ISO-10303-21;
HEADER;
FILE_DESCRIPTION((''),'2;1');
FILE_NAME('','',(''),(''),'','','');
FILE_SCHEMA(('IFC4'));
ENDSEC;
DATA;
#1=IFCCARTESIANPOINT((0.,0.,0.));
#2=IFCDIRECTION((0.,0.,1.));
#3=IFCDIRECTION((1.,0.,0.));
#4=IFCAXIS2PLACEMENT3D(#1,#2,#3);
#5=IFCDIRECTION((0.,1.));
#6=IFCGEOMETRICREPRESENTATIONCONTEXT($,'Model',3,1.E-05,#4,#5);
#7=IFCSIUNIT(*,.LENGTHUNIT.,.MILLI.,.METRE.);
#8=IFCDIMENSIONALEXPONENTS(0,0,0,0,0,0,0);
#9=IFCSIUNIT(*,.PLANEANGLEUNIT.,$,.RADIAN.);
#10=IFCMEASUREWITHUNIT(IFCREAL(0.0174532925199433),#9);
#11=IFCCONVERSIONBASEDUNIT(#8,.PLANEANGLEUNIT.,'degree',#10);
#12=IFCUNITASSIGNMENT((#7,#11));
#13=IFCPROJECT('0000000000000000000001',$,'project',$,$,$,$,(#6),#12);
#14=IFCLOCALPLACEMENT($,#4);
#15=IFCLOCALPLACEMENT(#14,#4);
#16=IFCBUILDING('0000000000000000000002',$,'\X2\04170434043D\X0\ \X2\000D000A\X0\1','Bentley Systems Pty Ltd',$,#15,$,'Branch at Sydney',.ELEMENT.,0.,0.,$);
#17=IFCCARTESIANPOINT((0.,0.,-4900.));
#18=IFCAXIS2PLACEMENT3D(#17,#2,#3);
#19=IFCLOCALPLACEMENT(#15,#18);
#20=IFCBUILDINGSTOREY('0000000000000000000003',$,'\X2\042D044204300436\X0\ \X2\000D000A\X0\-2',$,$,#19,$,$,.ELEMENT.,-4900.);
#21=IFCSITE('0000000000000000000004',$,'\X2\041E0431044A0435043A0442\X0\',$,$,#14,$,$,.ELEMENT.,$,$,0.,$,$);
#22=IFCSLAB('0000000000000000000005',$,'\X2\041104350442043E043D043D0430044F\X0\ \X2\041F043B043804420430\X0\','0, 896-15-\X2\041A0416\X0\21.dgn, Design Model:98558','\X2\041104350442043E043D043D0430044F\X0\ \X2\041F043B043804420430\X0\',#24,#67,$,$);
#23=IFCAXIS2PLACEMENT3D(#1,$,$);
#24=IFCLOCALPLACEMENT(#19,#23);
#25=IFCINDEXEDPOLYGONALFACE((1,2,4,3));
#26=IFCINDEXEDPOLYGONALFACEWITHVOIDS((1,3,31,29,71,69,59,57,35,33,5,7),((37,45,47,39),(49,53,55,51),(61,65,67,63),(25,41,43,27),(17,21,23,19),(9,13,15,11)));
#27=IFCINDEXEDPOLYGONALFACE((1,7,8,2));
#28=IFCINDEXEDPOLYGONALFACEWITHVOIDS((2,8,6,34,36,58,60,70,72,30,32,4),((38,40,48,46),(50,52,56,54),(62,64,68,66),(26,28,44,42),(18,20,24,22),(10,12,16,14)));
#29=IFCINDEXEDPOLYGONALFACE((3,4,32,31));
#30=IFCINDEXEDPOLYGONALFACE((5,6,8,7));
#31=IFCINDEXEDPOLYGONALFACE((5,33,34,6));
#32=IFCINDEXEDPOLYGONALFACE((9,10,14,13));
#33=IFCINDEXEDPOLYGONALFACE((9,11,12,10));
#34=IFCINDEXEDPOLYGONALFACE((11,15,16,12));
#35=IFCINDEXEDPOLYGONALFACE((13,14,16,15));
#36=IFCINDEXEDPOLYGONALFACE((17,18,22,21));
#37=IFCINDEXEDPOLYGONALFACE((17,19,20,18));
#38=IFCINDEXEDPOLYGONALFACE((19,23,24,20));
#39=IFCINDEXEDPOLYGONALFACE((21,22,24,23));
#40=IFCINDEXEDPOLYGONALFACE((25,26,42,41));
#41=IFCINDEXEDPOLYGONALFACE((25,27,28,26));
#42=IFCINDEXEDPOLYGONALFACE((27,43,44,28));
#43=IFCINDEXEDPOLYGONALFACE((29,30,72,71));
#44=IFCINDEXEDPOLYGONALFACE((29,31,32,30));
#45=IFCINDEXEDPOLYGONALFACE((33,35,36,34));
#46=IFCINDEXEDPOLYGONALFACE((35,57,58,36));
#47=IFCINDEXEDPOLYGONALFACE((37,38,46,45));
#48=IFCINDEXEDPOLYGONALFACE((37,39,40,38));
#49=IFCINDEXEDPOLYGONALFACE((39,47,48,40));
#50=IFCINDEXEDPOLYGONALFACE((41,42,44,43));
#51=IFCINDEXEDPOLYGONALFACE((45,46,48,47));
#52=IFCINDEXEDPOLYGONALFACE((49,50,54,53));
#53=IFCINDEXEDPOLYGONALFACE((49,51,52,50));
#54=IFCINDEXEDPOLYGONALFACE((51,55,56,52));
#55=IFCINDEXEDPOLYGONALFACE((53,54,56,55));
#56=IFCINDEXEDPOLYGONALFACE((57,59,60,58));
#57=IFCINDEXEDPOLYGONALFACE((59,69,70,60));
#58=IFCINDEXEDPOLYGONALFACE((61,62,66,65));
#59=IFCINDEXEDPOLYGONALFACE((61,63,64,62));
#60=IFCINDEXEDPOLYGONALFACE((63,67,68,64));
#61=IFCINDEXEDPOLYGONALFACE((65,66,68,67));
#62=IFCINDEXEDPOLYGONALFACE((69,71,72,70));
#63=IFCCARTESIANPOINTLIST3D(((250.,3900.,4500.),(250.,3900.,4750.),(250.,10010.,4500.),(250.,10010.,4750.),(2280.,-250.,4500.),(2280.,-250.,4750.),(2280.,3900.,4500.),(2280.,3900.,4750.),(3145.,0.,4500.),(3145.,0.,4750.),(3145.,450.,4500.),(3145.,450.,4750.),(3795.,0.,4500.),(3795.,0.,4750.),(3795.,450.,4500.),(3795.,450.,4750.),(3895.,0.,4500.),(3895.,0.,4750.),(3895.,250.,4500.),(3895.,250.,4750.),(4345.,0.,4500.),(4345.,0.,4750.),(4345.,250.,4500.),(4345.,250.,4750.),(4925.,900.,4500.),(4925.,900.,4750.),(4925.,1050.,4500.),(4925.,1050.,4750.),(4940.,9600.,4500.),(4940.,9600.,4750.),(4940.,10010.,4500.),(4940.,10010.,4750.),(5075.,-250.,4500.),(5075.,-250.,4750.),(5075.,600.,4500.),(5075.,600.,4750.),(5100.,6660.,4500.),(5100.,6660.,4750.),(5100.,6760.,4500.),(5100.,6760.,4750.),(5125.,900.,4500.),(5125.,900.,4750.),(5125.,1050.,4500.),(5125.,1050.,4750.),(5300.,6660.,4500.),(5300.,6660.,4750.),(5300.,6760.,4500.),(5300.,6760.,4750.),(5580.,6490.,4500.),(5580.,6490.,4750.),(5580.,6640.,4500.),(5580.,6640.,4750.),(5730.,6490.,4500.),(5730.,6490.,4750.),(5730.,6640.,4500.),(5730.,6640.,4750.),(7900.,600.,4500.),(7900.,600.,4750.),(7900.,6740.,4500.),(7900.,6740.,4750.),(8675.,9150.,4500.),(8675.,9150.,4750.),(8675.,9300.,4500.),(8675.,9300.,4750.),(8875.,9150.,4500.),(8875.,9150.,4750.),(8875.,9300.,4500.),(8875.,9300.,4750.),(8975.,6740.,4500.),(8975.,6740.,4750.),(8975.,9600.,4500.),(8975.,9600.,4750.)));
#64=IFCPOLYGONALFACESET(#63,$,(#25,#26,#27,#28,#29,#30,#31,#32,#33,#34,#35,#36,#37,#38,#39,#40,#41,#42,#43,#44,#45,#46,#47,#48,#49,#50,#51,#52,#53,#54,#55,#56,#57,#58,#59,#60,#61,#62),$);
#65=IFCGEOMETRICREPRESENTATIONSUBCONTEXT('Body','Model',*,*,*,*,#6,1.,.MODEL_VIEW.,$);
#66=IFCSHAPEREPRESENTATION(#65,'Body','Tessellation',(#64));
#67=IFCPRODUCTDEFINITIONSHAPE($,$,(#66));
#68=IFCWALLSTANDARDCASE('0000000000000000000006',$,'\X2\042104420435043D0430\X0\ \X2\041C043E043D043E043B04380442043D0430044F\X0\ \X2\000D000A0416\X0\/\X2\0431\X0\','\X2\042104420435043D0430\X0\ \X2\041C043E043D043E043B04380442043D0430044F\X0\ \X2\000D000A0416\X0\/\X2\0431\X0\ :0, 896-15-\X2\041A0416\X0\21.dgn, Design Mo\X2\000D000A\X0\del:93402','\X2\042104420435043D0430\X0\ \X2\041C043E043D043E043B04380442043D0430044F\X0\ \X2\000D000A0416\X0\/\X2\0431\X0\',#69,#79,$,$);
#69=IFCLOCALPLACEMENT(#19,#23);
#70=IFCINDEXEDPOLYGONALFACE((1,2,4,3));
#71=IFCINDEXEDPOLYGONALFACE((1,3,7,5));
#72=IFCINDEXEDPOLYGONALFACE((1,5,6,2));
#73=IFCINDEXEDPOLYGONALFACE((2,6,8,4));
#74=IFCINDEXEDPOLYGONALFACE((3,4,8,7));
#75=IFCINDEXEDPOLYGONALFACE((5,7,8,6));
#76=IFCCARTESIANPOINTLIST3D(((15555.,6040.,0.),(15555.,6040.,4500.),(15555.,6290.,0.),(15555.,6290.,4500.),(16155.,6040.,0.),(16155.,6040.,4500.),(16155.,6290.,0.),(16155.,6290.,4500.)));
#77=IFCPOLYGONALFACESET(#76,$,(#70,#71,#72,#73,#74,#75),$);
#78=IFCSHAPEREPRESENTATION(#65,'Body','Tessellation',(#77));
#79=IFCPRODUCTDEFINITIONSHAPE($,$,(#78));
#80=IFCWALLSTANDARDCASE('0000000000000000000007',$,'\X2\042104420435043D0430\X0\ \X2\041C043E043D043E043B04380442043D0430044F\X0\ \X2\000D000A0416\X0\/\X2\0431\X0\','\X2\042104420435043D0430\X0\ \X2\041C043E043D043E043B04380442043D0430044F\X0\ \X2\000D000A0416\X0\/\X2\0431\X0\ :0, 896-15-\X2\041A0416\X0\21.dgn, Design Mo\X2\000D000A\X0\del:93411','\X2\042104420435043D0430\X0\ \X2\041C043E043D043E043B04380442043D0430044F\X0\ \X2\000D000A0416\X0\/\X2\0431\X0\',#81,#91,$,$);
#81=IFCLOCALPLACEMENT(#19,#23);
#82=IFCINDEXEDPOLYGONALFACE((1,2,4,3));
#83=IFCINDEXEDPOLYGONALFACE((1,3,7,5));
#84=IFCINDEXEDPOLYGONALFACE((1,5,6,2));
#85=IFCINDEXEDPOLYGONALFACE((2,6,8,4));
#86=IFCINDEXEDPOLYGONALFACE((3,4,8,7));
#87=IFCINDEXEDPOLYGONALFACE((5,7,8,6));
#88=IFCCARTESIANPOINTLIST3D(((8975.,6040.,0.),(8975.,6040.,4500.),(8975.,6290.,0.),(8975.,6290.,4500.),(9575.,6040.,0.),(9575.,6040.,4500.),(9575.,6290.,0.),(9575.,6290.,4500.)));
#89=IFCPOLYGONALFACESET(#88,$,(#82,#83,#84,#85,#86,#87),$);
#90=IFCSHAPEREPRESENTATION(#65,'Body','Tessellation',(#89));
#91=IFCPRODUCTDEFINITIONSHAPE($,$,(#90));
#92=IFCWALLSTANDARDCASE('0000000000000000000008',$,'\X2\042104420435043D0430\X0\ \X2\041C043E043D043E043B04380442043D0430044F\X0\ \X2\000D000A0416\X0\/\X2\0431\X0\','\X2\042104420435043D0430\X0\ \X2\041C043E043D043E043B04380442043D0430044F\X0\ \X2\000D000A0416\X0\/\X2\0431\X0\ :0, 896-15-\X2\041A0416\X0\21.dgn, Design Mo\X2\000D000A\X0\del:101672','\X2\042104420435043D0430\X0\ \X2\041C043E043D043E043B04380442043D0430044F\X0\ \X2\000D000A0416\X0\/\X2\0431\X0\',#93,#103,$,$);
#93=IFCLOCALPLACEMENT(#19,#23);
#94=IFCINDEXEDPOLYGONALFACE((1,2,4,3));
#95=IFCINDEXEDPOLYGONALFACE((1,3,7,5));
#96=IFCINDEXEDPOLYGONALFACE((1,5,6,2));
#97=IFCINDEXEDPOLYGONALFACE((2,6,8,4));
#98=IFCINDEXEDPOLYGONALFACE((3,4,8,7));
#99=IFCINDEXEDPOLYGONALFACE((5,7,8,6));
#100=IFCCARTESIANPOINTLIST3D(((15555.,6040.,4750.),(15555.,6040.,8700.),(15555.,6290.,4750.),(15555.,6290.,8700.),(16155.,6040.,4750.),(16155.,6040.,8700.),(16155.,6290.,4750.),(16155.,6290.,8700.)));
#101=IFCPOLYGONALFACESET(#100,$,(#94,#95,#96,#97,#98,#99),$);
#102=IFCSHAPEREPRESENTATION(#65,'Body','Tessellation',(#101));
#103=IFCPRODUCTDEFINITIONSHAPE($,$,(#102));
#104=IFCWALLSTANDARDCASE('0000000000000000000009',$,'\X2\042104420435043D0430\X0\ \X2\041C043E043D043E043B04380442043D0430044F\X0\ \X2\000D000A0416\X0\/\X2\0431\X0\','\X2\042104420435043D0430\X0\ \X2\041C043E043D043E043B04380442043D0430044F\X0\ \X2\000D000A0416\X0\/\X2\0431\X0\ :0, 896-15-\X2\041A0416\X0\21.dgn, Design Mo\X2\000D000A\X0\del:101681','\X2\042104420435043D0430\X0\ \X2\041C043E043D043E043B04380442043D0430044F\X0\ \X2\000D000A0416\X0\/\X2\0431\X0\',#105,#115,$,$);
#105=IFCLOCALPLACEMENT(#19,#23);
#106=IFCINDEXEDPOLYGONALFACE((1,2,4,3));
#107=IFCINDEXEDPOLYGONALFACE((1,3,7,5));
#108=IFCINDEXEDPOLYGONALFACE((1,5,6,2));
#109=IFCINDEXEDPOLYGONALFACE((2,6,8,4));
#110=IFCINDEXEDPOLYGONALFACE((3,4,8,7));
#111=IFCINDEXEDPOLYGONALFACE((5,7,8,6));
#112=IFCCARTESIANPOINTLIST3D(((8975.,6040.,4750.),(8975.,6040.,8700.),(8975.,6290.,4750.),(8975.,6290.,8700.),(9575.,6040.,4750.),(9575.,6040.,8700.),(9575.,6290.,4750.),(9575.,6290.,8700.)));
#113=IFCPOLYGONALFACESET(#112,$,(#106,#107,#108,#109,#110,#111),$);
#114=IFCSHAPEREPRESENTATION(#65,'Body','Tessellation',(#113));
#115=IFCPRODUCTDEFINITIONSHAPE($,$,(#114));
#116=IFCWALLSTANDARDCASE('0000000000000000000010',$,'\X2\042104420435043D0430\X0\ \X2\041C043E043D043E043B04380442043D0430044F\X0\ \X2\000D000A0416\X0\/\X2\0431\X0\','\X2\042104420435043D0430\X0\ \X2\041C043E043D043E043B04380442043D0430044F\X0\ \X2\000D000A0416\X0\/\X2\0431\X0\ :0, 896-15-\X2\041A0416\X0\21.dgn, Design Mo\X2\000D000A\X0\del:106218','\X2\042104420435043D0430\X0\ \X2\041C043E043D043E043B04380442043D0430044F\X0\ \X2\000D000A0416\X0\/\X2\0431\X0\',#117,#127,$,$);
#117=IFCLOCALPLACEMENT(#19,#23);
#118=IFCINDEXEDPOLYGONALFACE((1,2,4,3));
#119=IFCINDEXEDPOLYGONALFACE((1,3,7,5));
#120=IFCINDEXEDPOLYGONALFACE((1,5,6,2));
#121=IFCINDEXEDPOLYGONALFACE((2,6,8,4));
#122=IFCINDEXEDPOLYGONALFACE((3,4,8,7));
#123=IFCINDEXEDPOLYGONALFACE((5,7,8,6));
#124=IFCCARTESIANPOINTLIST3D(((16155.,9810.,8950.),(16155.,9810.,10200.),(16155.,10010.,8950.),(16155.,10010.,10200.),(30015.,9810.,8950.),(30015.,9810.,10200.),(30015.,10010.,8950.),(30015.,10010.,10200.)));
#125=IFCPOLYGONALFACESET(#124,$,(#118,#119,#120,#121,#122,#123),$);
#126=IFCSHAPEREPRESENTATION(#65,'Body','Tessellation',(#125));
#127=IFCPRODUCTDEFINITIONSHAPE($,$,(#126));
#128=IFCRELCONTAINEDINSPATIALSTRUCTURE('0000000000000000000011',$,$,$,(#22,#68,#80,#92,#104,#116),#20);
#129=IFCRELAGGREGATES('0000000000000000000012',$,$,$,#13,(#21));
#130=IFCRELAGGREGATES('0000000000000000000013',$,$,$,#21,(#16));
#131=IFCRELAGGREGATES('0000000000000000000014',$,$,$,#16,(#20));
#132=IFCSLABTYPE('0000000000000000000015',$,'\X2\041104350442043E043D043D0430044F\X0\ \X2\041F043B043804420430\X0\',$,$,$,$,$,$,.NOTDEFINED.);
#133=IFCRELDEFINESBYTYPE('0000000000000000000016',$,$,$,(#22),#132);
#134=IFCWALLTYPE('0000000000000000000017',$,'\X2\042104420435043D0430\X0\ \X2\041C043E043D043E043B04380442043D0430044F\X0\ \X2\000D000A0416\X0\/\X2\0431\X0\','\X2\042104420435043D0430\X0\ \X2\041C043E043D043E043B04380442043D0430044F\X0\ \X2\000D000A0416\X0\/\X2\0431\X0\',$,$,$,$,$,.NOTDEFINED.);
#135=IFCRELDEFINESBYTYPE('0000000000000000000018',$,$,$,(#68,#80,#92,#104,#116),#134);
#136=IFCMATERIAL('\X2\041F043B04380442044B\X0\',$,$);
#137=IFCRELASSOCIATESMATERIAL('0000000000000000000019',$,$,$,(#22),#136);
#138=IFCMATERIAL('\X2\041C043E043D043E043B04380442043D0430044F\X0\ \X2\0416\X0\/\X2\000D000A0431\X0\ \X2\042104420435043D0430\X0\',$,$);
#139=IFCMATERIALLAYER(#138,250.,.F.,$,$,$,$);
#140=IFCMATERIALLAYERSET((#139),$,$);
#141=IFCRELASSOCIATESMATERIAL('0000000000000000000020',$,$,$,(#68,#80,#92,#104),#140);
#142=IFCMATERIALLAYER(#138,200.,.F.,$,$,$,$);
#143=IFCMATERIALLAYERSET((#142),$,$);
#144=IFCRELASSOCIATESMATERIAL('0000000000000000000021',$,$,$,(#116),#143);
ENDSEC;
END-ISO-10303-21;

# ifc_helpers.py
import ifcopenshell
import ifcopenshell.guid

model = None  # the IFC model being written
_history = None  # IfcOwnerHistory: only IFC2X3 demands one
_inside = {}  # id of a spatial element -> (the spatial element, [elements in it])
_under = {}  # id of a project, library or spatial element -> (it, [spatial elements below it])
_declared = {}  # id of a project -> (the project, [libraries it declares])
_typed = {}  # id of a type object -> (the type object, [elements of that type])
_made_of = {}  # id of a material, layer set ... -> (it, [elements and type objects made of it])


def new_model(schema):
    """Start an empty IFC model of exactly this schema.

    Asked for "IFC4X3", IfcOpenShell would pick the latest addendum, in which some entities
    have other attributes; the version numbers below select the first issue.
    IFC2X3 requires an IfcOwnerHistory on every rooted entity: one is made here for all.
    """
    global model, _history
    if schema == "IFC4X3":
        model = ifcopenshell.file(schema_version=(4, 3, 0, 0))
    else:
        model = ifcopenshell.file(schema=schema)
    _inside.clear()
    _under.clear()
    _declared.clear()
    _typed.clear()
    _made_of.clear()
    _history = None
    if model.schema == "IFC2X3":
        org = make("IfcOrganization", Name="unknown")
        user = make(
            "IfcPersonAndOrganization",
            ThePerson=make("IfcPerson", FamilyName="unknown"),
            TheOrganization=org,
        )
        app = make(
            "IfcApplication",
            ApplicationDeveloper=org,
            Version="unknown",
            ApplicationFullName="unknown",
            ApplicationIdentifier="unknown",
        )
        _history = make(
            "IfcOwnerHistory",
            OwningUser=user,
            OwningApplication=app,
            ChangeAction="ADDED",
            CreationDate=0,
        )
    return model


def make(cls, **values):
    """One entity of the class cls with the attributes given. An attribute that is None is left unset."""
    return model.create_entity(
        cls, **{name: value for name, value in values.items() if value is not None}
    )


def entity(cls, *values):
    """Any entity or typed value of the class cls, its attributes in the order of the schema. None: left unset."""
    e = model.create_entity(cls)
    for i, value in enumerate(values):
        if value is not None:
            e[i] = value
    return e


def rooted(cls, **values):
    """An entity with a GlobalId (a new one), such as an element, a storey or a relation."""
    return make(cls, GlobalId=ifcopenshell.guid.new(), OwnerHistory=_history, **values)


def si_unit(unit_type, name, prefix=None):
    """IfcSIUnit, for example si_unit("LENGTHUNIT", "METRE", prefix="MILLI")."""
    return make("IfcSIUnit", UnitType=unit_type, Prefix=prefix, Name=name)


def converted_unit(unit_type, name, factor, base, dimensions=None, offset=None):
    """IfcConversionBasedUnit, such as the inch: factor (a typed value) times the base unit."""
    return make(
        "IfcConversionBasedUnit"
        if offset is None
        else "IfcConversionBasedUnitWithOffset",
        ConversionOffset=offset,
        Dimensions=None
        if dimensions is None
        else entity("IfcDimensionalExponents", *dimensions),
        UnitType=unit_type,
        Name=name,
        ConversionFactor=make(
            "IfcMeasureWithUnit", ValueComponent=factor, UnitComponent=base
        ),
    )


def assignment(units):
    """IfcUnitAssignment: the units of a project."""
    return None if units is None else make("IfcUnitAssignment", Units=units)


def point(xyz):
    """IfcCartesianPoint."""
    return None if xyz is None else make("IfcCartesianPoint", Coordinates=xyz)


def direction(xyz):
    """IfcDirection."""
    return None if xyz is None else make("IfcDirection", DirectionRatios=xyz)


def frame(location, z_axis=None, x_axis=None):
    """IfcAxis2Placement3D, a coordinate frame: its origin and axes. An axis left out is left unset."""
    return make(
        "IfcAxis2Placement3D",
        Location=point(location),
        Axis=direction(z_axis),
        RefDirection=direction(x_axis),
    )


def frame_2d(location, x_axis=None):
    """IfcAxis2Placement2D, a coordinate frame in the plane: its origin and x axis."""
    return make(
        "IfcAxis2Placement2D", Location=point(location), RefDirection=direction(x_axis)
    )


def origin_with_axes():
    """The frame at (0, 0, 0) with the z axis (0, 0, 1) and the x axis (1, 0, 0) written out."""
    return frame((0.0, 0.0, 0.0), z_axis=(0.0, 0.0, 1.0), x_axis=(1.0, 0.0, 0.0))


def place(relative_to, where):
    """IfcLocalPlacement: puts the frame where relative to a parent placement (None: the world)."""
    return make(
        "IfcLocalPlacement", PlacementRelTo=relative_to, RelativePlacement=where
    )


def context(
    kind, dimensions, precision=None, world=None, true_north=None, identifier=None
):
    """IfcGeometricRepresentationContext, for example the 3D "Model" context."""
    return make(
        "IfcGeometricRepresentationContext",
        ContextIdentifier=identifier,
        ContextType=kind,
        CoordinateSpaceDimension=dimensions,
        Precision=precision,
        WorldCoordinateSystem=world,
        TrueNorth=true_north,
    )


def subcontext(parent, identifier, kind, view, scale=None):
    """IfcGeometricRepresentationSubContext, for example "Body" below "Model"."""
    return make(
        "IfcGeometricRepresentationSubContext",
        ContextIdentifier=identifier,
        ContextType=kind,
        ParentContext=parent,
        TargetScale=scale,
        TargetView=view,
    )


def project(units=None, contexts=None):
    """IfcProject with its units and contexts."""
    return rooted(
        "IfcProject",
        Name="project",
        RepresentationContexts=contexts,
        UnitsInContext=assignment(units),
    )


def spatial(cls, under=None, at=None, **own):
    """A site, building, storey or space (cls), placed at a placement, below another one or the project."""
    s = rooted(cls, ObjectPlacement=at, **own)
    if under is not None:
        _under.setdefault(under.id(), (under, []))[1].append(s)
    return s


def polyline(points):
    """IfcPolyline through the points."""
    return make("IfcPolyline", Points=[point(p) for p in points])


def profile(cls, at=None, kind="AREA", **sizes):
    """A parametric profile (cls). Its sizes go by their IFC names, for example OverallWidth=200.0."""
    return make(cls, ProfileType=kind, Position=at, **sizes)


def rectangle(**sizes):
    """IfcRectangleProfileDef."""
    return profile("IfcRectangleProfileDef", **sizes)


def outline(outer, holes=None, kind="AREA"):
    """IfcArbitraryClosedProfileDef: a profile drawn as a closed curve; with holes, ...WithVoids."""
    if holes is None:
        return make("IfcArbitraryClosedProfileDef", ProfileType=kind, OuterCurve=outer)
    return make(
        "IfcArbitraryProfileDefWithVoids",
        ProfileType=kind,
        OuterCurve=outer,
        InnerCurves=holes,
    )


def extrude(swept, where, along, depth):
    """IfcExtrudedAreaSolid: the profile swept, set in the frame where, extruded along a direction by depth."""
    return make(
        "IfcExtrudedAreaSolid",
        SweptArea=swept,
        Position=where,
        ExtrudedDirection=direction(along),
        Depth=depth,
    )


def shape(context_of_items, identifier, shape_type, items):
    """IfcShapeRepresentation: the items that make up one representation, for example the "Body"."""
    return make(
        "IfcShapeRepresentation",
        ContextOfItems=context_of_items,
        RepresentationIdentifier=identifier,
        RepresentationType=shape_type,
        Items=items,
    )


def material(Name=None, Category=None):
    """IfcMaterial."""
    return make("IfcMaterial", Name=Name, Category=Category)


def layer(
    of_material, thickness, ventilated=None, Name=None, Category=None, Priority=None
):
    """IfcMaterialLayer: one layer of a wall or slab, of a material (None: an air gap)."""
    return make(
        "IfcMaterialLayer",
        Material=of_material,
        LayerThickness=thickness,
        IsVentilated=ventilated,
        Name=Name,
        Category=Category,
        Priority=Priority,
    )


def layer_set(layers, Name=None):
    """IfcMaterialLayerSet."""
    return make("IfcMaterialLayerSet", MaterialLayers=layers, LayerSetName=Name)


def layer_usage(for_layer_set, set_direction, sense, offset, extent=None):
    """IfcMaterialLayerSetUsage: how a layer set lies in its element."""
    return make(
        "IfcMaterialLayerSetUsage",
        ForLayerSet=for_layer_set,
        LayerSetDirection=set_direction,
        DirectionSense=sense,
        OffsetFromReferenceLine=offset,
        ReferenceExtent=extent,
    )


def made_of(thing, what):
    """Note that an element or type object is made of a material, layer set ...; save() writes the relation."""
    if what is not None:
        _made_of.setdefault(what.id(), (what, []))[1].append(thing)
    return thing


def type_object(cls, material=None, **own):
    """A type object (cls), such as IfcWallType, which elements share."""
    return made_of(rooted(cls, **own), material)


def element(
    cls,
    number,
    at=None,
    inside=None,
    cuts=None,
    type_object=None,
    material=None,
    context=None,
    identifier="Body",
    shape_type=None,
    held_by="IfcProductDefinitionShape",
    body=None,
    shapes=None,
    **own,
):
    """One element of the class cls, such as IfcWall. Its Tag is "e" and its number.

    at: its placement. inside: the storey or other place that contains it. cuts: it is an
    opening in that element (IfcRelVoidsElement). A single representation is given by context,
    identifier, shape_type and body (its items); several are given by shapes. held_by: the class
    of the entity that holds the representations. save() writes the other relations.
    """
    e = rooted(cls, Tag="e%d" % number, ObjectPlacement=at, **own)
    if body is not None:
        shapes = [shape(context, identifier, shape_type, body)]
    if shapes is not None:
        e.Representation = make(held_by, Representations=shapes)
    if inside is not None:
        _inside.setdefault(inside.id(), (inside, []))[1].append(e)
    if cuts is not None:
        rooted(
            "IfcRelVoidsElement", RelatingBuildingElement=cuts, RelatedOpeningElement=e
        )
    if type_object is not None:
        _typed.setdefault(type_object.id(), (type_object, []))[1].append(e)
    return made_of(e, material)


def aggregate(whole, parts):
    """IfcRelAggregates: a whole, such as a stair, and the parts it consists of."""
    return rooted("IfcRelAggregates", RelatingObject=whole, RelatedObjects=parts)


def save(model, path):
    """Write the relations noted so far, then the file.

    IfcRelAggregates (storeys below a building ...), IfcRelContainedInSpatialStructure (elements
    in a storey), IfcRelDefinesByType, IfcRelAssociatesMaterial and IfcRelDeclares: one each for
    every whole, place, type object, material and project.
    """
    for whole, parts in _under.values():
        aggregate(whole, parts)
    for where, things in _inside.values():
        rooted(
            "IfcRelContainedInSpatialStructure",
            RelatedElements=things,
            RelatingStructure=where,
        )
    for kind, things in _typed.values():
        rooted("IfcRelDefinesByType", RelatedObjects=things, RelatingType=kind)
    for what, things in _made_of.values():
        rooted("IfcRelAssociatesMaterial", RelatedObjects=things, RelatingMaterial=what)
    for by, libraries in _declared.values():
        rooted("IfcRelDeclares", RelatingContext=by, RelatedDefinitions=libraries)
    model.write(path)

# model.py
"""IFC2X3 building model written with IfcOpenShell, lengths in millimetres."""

from ifc_helpers import new_model, entity, si_unit, converted_unit, direction, frame, frame_2d, origin_with_axes, place, context, subcontext, project, spatial, polyline, rectangle, outline, extrude, material, layer, layer_set, layer_usage, type_object, element, save


model = new_model("IFC2X3")

# Units and contexts
model_context = context("Model", 3, precision=1e-05, world=origin_with_axes(), true_north=direction((0.0, 1.0)))
body_context = subcontext(model_context, "Body", "Model", "MODEL_VIEW", scale=1.0)
ifc_project = project(units=[si_unit("LENGTHUNIT", "METRE", prefix="MILLI"), converted_unit("PLANEANGLEUNIT", "degree", entity("IfcReal", 0.0174532925199433), si_unit("PLANEANGLEUNIT", "RADIAN"), dimensions=[0, 0, 0, 0, 0, 0, 0])], contexts=[model_context])

# Site, building, storey
site_placement = place(None, origin_with_axes())
site = spatial("IfcSite", under=ifc_project, at=site_placement, Name="Объект", CompositionType="ELEMENT", RefElevation=0.0)
building_placement = place(site_placement, origin_with_axes())
building = spatial("IfcBuilding", under=site, at=building_placement, Name="Здн \r\n1", Description="Bentley Systems Pty Ltd", LongName="Branch at Sydney", CompositionType="ELEMENT", ElevationOfRefHeight=0.0, ElevationOfTerrain=0.0)
storey_placement = place(building_placement, frame((0.0, 0.0, -4900.0), z_axis=(0.0, 0.0, 1.0), x_axis=(1.0, 0.0, 0.0)))
storey = spatial("IfcBuildingStorey", under=building, at=storey_placement, Name="Этаж \r\n-2", CompositionType="ELEMENT", Elevation=-4900.0)

# Shared definitions
ifc_material_1 = material(Name="Плиты")
slab_type = type_object("IfcSlabType", Name="Бетонная Плита", PredefinedType="NOTDEFINED")

# Slab, openings
slab_1_placement = place(storey_placement, frame((8975.0, 9600.0, 4750.0), z_axis=(0.0, 0.0, -1.0), x_axis=(0.0, -1.0, 0.0)))
slab_1 = element("IfcSlab", 1, at=slab_1_placement, inside=storey, type_object=slab_type, material=ifc_material_1, Name="Бетонная Плита", Description="0, 896-15-КЖ21.dgn, Design Model:98558", ObjectType="Бетонная Плита", context=body_context, shape_type="SweptSolid", body=[
    extrude(outline(polyline([(0.0, 0.0), (2860.0, 0.0), (2860.0, 1075.0), (9000.0, 1075.0), (9000.0, 3900.0), (9850.0, 3900.0), (9850.0, 6695.0), (5700.0, 6695.0), (5700.0, 8725.0), (-410.0, 8725.0), (-410.0, 4035.0), (0.0, 4035.0), (0.0, 0.0)])), origin_with_axes(), (0.0, 0.0, 1.0), 250.0),
])
opening_1_placement = place(slab_1_placement, frame((300.0, 100.0, 0.0), z_axis=(0.0, 0.0, 1.0), x_axis=(1.0, 0.0, 0.0)))
element("IfcOpeningElement", 2, at=opening_1_placement, cuts=slab_1, ObjectType="Opening", context=body_context, shape_type="SweptSolid", body=[
    extrude(rectangle(XDim=200.0, YDim=150.0, at=frame_2d((-75.0, 100.0), x_axis=(0.0, 1.0))), frame((0.0, 0.0, 375.0), z_axis=(0.0, 0.0, -1.0), x_axis=(-1.0, 0.0, 0.0)), (0.0, 0.0, 1.0), 750.0),
])
opening_2_placement = place(slab_1_placement, frame((2960.0, 3245.0, 0.0), z_axis=(0.0, 0.0, 1.0), x_axis=(1.0, 0.0, 0.0)))
element("IfcOpeningElement", 3, at=opening_2_placement, cuts=slab_1, ObjectType="Opening", context=body_context, shape_type="SweptSolid", body=[
    extrude(rectangle(XDim=150.0, YDim=150.0, at=frame_2d((-75.0, 75.0), x_axis=(0.0, 1.0))), frame((0.0, 0.0, 375.0), z_axis=(0.0, 0.0, -1.0), x_axis=(-1.0, 0.0, 0.0)), (0.0, 0.0, 1.0), 750.0),
])
opening_3_placement = place(slab_1_placement, frame((2840.0, 3675.0, 0.0), z_axis=(0.0, 0.0, 1.0), x_axis=(1.0, 0.0, 0.0)))
element("IfcOpeningElement", 4, at=opening_3_placement, cuts=slab_1, ObjectType="Opening", context=body_context, shape_type="SweptSolid", body=[
    extrude(rectangle(XDim=200.0, YDim=100.0, at=frame_2d((-50.0, 100.0), x_axis=(0.0, 1.0))), frame((0.0, 0.0, 375.0), z_axis=(0.0, 0.0, -1.0), x_axis=(-1.0, 0.0, 0.0)), (0.0, 0.0, 1.0), 750.0),
])
opening_4_placement = place(slab_1_placement, frame((9150.0, 5180.0, 0.0), z_axis=(0.0, 0.0, 1.0), x_axis=(1.0, 0.0, 0.0)))
element("IfcOpeningElement", 5, at=opening_4_placement, cuts=slab_1, ObjectType="Opening", context=body_context, shape_type="SweptSolid", body=[
    extrude(rectangle(XDim=650.0, YDim=450.0, at=frame_2d((-225.0, 325.0), x_axis=(0.0, 1.0))), frame((0.0, 0.0, 375.0), z_axis=(0.0, 0.0, -1.0), x_axis=(-1.0, 0.0, 0.0)), (0.0, 0.0, 1.0), 750.0),
])
opening_5_placement = place(slab_1_placement, frame((9350.0, 4630.0, 0.0), z_axis=(0.0, 0.0, 1.0), x_axis=(1.0, 0.0, 0.0)))
element("IfcOpeningElement", 6, at=opening_5_placement, cuts=slab_1, ObjectType="Opening", context=body_context, shape_type="SweptSolid", body=[
    extrude(rectangle(XDim=450.0, YDim=250.0, at=frame_2d((-125.0, 225.0), x_axis=(0.0, 1.0))), frame((0.0, 0.0, 375.0), z_axis=(0.0, 0.0, -1.0), x_axis=(-1.0, 0.0, 0.0)), (0.0, 0.0, 1.0), 750.0),
])
opening_6_placement = place(slab_1_placement, frame((8550.0, 3850.0, 0.0), z_axis=(0.0, 0.0, 1.0), x_axis=(1.0, 0.0, 0.0)))
element("IfcOpeningElement", 7, at=opening_6_placement, cuts=slab_1, ObjectType="Opening", context=body_context, shape_type="SweptSolid", body=[
    extrude(rectangle(XDim=200.0, YDim=150.0, at=frame_2d((-75.0, 100.0), x_axis=(0.0, 1.0))), frame((0.0, 0.0, 375.0), z_axis=(0.0, 0.0, -1.0), x_axis=(-1.0, 0.0, 0.0)), (0.0, 0.0, 1.0), 750.0),
])

# Walls
ifc_material_2 = material(Name="Монолитная Ж/\r\nб Стена")
ifc_layer_1 = layer(ifc_material_2, 250.0, ventilated=False)
ifc_layer_set_1 = layer_set([ifc_layer_1])
ifc_layer_usage_1 = layer_usage(ifc_layer_set_1, "AXIS2", "POSITIVE", 0.0)
wall_type = type_object("IfcWallType", Name="Стена Монолитная \r\nЖ/б", Description="Стена Монолитная \r\nЖ/б", PredefinedType="NOTDEFINED")
for number, where, z_axis, x_axis, name, description in (
    (8, (15555.0, 6040.0, 0.0), (0.0, 0.0, 1.0), (1.0, 0.0, 0.0), "Стена Монолитная \r\nЖ/б", "Стена Монолитная \r\nЖ/б :0, 896-15-КЖ21.dgn, Design Mo\r\ndel:93402"),
    (9, (8975.0, 6040.0, 0.0), (0.0, 0.0, 1.0), (1.0, 0.0, 0.0), "Стена Монолитная \r\nЖ/б", "Стена Монолитная \r\nЖ/б :0, 896-15-КЖ21.dgn, Design Mo\r\ndel:93411"),
):
    element("IfcWallStandardCase", number, at=place(storey_placement, frame(where, z_axis=z_axis, x_axis=x_axis)), inside=storey, type_object=wall_type, material=ifc_layer_usage_1, Name=name, Description=description, ObjectType="Стена Монолитная \r\nЖ/б", context=body_context, shape_type="SweptSolid", body=[
        extrude(rectangle(XDim=600.0, YDim=250.0, at=frame_2d((300.0, 125.0), x_axis=(1.0, 0.0))), origin_with_axes(), (0.0, 0.0, 1.0), 4500.0),
    ])
for number, where, z_axis, x_axis, name, description in (
    (10, (15555.0, 6040.0, 4750.0), (0.0, 0.0, 1.0), (1.0, 0.0, 0.0), "Стена Монолитная \r\nЖ/б", "Стена Монолитная \r\nЖ/б :0, 896-15-КЖ21.dgn, Design Mo\r\ndel:101672"),
    (11, (8975.0, 6040.0, 4750.0), (0.0, 0.0, 1.0), (1.0, 0.0, 0.0), "Стена Монолитная \r\nЖ/б", "Стена Монолитная \r\nЖ/б :0, 896-15-КЖ21.dgn, Design Mo\r\ndel:101681"),
):
    element("IfcWallStandardCase", number, at=place(storey_placement, frame(where, z_axis=z_axis, x_axis=x_axis)), inside=storey, type_object=wall_type, material=ifc_layer_usage_1, Name=name, Description=description, ObjectType="Стена Монолитная \r\nЖ/б", context=body_context, shape_type="SweptSolid", body=[
        extrude(rectangle(XDim=600.0, YDim=250.0, at=frame_2d((300.0, 125.0), x_axis=(1.0, 0.0))), origin_with_axes(), (0.0, 0.0, 1.0), 3950.0),
    ])
ifc_layer_2 = layer(ifc_material_2, 200.0, ventilated=False)
ifc_layer_set_2 = layer_set([ifc_layer_2])
ifc_layer_usage_2 = layer_usage(ifc_layer_set_2, "AXIS2", "POSITIVE", 0.0)
wall_placement = place(storey_placement, frame((16155.0, 10010.0, 8950.0), z_axis=(0.0, 0.0, 1.0), x_axis=(1.0, 0.0, 0.0)))
element("IfcWallStandardCase", 12, at=wall_placement, inside=storey, type_object=wall_type, material=ifc_layer_usage_2, Name="Стена Монолитная \r\nЖ/б", Description="Стена Монолитная \r\nЖ/б :0, 896-15-КЖ21.dgn, Design Mo\r\ndel:106218", ObjectType="Стена Монолитная \r\nЖ/б", context=body_context, shape_type="SweptSolid", body=[
    extrude(rectangle(XDim=13860.0, YDim=200.0, at=frame_2d((6930.0, -100.0), x_axis=(1.0, 0.0))), origin_with_axes(), (0.0, 0.0, 1.0), 1250.0),
])

save(model, "model.ifc")
